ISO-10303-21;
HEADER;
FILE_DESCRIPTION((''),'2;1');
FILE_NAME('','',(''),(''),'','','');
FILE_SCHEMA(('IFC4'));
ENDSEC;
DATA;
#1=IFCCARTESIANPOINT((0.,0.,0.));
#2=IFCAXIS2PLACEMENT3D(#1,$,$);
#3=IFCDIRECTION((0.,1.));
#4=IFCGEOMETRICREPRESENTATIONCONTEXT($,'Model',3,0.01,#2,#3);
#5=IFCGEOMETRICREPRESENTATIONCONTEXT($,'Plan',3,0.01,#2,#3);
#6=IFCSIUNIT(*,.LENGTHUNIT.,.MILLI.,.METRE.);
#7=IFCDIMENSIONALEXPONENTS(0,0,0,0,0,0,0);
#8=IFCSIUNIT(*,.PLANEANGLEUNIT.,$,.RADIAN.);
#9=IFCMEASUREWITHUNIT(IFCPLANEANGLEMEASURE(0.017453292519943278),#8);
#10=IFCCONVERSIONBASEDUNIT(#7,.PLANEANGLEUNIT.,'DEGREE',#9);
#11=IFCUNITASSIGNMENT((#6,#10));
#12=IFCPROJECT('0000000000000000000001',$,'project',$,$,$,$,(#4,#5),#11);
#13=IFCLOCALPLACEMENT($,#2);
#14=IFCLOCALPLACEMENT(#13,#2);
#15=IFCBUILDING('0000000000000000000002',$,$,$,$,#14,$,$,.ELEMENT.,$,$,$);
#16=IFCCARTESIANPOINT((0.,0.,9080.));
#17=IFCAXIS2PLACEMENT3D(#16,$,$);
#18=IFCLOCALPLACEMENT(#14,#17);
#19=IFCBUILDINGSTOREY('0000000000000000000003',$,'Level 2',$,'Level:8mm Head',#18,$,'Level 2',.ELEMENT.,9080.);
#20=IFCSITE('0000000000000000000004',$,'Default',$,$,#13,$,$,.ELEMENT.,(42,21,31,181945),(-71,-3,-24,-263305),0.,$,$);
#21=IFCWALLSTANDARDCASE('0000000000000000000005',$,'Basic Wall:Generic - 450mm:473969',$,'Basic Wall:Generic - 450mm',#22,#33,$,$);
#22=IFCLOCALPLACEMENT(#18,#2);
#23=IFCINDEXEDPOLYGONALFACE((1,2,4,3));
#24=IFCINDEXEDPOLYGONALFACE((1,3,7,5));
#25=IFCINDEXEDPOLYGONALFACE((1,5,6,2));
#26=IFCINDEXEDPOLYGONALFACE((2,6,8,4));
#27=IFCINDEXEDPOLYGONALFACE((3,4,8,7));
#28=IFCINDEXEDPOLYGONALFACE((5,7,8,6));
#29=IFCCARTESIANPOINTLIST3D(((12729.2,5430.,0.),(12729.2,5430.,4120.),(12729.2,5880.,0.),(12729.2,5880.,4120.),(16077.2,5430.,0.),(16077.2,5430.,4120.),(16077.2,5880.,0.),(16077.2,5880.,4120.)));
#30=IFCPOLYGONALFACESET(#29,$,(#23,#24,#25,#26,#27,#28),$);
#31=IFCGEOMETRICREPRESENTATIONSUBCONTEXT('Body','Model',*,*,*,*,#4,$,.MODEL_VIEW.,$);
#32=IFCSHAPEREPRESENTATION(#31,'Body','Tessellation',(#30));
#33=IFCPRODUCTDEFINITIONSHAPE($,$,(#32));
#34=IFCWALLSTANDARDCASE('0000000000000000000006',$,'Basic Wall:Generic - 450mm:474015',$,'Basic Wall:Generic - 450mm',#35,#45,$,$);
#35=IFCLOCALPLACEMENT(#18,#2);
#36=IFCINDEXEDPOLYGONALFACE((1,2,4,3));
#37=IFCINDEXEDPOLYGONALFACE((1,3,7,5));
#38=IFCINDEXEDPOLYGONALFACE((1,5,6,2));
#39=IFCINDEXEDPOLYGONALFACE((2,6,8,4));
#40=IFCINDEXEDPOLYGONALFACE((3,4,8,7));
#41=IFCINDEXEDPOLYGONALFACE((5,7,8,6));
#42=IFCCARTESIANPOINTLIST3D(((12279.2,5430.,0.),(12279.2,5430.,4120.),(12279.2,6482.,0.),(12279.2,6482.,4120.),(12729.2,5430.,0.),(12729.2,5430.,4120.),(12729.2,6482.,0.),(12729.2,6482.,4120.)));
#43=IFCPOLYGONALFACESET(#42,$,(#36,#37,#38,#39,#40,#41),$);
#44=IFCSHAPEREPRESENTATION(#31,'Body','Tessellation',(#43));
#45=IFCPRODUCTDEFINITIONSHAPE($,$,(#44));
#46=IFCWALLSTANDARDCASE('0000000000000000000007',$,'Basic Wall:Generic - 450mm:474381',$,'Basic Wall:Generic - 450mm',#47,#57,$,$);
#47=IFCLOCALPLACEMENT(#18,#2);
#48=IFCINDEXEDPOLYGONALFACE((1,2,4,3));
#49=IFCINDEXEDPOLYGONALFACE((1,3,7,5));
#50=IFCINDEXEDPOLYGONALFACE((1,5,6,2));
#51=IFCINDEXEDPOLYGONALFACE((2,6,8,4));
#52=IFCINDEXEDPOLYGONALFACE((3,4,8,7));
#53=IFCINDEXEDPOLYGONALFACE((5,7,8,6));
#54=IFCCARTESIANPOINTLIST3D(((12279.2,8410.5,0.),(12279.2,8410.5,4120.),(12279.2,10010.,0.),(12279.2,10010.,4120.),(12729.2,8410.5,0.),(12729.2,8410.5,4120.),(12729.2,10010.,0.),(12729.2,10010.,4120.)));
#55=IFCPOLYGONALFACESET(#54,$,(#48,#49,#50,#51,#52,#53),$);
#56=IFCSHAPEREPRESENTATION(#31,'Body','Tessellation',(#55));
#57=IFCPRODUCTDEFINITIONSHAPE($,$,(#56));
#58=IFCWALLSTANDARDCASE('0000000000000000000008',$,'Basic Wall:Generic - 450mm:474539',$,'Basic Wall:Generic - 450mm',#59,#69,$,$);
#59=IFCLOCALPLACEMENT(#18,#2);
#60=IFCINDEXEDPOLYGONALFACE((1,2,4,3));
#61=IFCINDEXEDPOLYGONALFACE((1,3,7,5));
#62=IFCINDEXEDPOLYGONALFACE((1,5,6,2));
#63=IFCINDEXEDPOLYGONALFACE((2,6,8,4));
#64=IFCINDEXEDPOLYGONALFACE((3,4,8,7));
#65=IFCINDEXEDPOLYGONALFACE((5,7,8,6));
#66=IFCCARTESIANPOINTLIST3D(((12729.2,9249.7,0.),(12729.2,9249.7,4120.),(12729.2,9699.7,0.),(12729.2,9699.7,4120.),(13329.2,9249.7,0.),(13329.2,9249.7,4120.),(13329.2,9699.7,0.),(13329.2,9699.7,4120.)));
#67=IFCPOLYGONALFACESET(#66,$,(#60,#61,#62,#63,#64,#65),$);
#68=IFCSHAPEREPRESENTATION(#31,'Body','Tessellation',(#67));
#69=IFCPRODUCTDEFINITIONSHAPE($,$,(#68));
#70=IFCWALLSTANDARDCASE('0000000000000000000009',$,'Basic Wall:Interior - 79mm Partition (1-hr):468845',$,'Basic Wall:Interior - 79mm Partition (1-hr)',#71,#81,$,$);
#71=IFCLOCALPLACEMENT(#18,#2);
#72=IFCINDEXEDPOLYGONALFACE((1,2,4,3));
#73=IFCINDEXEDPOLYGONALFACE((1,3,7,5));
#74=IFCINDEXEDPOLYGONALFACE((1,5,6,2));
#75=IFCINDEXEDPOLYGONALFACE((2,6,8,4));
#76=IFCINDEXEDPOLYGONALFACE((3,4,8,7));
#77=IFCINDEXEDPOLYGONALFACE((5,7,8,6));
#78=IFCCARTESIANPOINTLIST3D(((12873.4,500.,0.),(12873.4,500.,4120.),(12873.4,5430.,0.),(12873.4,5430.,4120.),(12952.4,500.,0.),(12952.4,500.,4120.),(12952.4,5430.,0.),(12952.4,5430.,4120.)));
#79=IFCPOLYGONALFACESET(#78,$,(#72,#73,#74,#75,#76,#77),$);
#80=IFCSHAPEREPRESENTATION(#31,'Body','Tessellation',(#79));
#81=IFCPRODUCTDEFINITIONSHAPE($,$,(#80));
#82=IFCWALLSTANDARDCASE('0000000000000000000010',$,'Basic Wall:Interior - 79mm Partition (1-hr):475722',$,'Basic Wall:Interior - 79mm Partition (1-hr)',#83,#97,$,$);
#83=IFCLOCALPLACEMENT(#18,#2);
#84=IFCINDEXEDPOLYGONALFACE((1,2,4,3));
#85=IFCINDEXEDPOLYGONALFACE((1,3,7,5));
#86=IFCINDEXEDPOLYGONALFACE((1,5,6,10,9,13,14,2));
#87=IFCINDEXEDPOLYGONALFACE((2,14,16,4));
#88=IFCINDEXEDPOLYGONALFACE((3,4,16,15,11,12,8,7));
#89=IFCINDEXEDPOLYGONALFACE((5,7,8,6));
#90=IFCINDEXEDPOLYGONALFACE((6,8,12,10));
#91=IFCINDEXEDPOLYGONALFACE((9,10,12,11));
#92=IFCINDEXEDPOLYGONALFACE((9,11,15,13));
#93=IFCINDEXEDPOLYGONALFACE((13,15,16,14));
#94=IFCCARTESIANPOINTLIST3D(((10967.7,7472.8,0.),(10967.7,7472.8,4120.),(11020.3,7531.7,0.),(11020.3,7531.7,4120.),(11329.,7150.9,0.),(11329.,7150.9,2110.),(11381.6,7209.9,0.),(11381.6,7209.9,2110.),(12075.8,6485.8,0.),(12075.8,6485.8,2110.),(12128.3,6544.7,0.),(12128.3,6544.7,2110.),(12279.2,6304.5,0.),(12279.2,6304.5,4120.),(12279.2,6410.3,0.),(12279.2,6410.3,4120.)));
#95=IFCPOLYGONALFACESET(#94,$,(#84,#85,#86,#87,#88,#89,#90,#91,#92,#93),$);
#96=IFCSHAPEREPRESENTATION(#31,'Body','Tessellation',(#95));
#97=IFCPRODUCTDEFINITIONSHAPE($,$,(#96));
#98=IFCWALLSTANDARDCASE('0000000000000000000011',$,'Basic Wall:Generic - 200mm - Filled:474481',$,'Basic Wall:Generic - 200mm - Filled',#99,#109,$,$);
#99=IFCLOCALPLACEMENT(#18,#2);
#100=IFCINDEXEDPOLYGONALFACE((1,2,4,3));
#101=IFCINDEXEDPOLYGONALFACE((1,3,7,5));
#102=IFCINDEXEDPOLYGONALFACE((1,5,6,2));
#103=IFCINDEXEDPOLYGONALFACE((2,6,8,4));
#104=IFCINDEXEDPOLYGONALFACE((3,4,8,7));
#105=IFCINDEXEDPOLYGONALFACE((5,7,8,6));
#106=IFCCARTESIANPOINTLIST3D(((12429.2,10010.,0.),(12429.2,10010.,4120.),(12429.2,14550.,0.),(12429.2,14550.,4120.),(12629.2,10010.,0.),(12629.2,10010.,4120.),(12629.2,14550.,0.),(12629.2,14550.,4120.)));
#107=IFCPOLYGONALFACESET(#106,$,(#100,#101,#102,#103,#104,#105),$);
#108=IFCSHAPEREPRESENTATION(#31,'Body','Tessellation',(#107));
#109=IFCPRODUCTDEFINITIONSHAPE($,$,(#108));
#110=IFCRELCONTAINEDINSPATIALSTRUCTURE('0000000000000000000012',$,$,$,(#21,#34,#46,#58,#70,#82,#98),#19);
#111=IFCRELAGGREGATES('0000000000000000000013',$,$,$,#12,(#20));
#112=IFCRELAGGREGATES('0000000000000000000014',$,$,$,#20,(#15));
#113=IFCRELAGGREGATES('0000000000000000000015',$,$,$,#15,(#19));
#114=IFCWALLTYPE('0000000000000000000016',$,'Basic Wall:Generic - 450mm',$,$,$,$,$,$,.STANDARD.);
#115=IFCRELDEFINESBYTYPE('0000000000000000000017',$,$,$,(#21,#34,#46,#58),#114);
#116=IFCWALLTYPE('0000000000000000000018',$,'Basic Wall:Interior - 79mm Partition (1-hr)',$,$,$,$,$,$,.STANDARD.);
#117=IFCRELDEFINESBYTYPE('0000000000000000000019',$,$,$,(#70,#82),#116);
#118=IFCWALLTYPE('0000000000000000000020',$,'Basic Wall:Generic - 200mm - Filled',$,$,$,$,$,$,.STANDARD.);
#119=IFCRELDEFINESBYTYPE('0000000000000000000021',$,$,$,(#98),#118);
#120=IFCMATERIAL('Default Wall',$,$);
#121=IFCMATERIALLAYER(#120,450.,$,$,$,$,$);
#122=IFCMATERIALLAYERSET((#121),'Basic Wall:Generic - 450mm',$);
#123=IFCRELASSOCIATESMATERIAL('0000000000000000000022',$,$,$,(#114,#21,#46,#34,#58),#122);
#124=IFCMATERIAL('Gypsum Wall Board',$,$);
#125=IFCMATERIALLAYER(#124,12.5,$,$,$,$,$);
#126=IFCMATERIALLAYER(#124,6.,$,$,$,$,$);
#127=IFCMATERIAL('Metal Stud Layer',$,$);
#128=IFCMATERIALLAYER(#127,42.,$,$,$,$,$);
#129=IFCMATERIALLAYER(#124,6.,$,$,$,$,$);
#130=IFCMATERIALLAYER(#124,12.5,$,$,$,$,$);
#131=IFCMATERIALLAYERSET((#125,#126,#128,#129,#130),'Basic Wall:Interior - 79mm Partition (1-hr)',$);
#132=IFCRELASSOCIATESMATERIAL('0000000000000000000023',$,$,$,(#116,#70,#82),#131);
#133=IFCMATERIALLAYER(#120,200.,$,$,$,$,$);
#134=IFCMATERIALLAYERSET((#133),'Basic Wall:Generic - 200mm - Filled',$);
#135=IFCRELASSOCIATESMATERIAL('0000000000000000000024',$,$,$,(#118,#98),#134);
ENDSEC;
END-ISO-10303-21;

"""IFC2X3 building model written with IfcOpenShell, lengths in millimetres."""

from ifc_helpers import new_model, entity, si_unit, converted_unit, direction, frame, frame_2d, origin, place, context, subcontext, project, spatial, polyline, rectangle, outline, extrude, material, layer, layer_set, layer_usage, type_object, element, save


model = new_model("IFC2X3")

# Units and contexts
model_context = context("Model", 3, precision=0.01, world=origin(), true_north=direction((0.0, 1.0)))
plan_context = context("Plan", 3, precision=0.01, world=origin(), true_north=direction((0.0, 1.0)))
body_context = subcontext(model_context, "Body", "Model", "MODEL_VIEW")
ifc_project = project(units=[si_unit("LENGTHUNIT", "METRE", prefix="MILLI"), converted_unit("PLANEANGLEUNIT", "DEGREE", entity("IfcPlaneAngleMeasure", 0.017453292519943278), si_unit("PLANEANGLEUNIT", "RADIAN"), dimensions=[0, 0, 0, 0, 0, 0, 0])], contexts=[model_context, plan_context])

# Site, building, storey
site_placement = place(None, origin())
site = spatial("IfcSite", under=ifc_project, at=site_placement, Name="Default", CompositionType="ELEMENT", RefLatitude=(42, 21, 31, 181945), RefLongitude=(-71, -3, -24, -263305), RefElevation=0.0)
building_placement = place(site_placement, origin())
building = spatial("IfcBuilding", under=site, at=building_placement, CompositionType="ELEMENT")
storey_placement = place(building_placement, frame((0.0, 0.0, 9080.0)))
storey = spatial("IfcBuildingStorey", under=building, at=storey_placement, Name="Level 2", ObjectType="Level:8mm Head", LongName="Level 2", CompositionType="ELEMENT", Elevation=9080.0)

# Walls
ifc_material_1 = material(Name="Default Wall")
ifc_layer_1 = layer(ifc_material_1, 450.0)
ifc_layer_set_1 = layer_set([ifc_layer_1], Name="Basic Wall:Generic - 450mm")
ifc_layer_usage_1 = layer_usage(ifc_layer_set_1, "AXIS2", "NEGATIVE", 225.0)
wall_type_1 = type_object("IfcWallType", Name="Basic Wall:Generic - 450mm", PredefinedType="STANDARD", material=ifc_layer_set_1)
wall_1_placement = place(storey_placement, frame((16077.2, 5655.0, 0.0), z_axis=(0.0, 0.0, 1.0), x_axis=(-1.0, 0.0, 0.0)))
element("IfcWallStandardCase", 1, at=wall_1_placement, inside=storey, type_object=wall_type_1, material=ifc_layer_usage_1, Name="Basic Wall:Generic - 450mm:473969", ObjectType="Basic Wall:Generic - 450mm", context=body_context, shape_type="SweptSolid", body=[
    extrude(rectangle(XDim=3348.0, YDim=450.0, at=frame_2d((1674.0, 0.0), x_axis=(-1.0, 0.0))), origin(), (0.0, 0.0, 1.0), 4120.0),
])
ifc_layer_usage_2 = layer_usage(ifc_layer_set_1, "AXIS2", "POSITIVE", -225.0)
wall_2_placement = place(storey_placement, frame((12504.2, 6482.0, 0.0), z_axis=(0.0, 0.0, 1.0), x_axis=(0.0, -1.0, 0.0)))
element("IfcWallStandardCase", 2, at=wall_2_placement, inside=storey, type_object=wall_type_1, material=ifc_layer_usage_2, Name="Basic Wall:Generic - 450mm:474015", ObjectType="Basic Wall:Generic - 450mm", context=body_context, shape_type="SweptSolid", body=[
    extrude(rectangle(XDim=1052.0, YDim=450.0, at=frame_2d((526.0, 0.0), x_axis=(-1.0, 0.0))), origin(), (0.0, 0.0, 1.0), 4120.0),
])
wall_3_placement = place(storey_placement, frame((12504.2, 8410.5, 0.0), z_axis=(0.0, 0.0, 1.0), x_axis=(0.0, 1.0, 0.0)))
element("IfcWallStandardCase", 3, at=wall_3_placement, inside=storey, type_object=wall_type_1, material=ifc_layer_usage_1, Name="Basic Wall:Generic - 450mm:474381", ObjectType="Basic Wall:Generic - 450mm", context=body_context, shape_type="SweptSolid", body=[
    extrude(rectangle(XDim=1599.5, YDim=450.0, at=frame_2d((799.7, 0.0), x_axis=(-1.0, 0.0))), origin(), (0.0, 0.0, 1.0), 4120.0),
])
wall_4_placement = place(storey_placement, frame((12729.2, 9474.7, 0.0)))
element("IfcWallStandardCase", 4, at=wall_4_placement, inside=storey, type_object=wall_type_1, material=ifc_layer_usage_2, Name="Basic Wall:Generic - 450mm:474539", ObjectType="Basic Wall:Generic - 450mm", context=body_context, shape_type="SweptSolid", body=[
    extrude(rectangle(XDim=600.0, YDim=450.0, at=frame_2d((300.0, 0.0), x_axis=(-1.0, 0.0))), origin(), (0.0, 0.0, 1.0), 4120.0),
])
ifc_material_2 = material(Name="Gypsum Wall Board")
ifc_layer_2 = layer(ifc_material_2, 12.5)
ifc_layer_3 = layer(ifc_material_2, 6.0)
ifc_material_3 = material(Name="Metal Stud Layer")
ifc_layer_4 = layer(ifc_material_3, 42.0)
ifc_layer_5 = layer(ifc_material_2, 6.0)
ifc_layer_6 = layer(ifc_material_2, 12.5)
ifc_layer_set_2 = layer_set([ifc_layer_2, ifc_layer_3, ifc_layer_4, ifc_layer_5, ifc_layer_6], Name="Basic Wall:Interior - 79mm Partition (1-hr)")
ifc_layer_usage_3 = layer_usage(ifc_layer_set_2, "AXIS2", "NEGATIVE", 39.5)
wall_type_2 = type_object("IfcWallType", Name="Basic Wall:Interior - 79mm Partition (1-hr)", PredefinedType="STANDARD", material=ifc_layer_set_2)
wall_5_placement = place(storey_placement, frame((12912.9, 500.0, 0.0), z_axis=(0.0, 0.0, 1.0), x_axis=(0.0, 1.0, 0.0)))
element("IfcWallStandardCase", 5, at=wall_5_placement, inside=storey, type_object=wall_type_2, material=ifc_layer_usage_3, Name="Basic Wall:Interior - 79mm Partition (1-hr):468845", ObjectType="Basic Wall:Interior - 79mm Partition (1-hr)", context=body_context, shape_type="SweptSolid", body=[
    extrude(rectangle(XDim=4930.0, YDim=79.0, at=frame_2d((2465.0, 0.0), x_axis=(-1.0, 0.0))), origin(), (0.0, 0.0, 1.0), 4120.0),
])

# Wall, opening
wall_6_placement = place(storey_placement, frame((12305.5, 6334.0, 0.0), z_axis=(0.0, 0.0, 1.0), x_axis=(-0.74672, 0.665138, 0.0)))
wall_6 = element("IfcWallStandardCase", 6, at=wall_6_placement, inside=storey, type_object=wall_type_2, material=ifc_layer_usage_3, Name="Basic Wall:Interior - 79mm Partition (1-hr):475722", ObjectType="Basic Wall:Interior - 79mm Partition (1-hr)", context=body_context, shape_type="SweptSolid", body=[
    extrude(outline(polyline([(70.4, -39.5), (1756.4, -39.5), (1756.4, 39.5), (0.0, 39.5), (70.4, -39.5)])), origin(), (0.0, 0.0, 1.0), 4120.0),
])
opening_placement = place(wall_6_placement, frame((272.5, -39.5, 0.0)))
element("IfcOpeningElement", 7, at=opening_placement, cuts=wall_6, ObjectType="Opening", context=body_context, shape_type="SweptSolid", body=[
    extrude(rectangle(XDim=2110.0, YDim=1000.0, at=frame_2d((1055.0, 500.0), x_axis=(1.0, 0.0))), frame((0.0, 0.0, 0.0), z_axis=(0.0, 1.0, 0.0), x_axis=(0.0, 0.0, 1.0)), (0.0, 0.0, 1.0), 79.0),
])

# Wall
ifc_layer_7 = layer(ifc_material_1, 200.0)
ifc_layer_set_3 = layer_set([ifc_layer_7], Name="Basic Wall:Generic - 200mm - Filled")
ifc_layer_usage_4 = layer_usage(ifc_layer_set_3, "AXIS2", "NEGATIVE", 100.0)
wall_type_3 = type_object("IfcWallType", Name="Basic Wall:Generic - 200mm - Filled", PredefinedType="STANDARD", material=ifc_layer_set_3)
wall_7_placement = place(storey_placement, frame((12529.2, 10010.0, 0.0), z_axis=(0.0, 0.0, 1.0), x_axis=(0.0, 1.0, 0.0)))
element("IfcWallStandardCase", 8, at=wall_7_placement, inside=storey, type_object=wall_type_3, material=ifc_layer_usage_4, Name="Basic Wall:Generic - 200mm - Filled:474481", ObjectType="Basic Wall:Generic - 200mm - Filled", context=body_context, shape_type="SweptSolid", body=[
    extrude(rectangle(XDim=4540.0, YDim=200.0, at=frame_2d((2270.0, 0.0), x_axis=(-1.0, 0.0))), origin(), (0.0, 0.0, 1.0), 4120.0),
])

save(model, "model.ifc")
